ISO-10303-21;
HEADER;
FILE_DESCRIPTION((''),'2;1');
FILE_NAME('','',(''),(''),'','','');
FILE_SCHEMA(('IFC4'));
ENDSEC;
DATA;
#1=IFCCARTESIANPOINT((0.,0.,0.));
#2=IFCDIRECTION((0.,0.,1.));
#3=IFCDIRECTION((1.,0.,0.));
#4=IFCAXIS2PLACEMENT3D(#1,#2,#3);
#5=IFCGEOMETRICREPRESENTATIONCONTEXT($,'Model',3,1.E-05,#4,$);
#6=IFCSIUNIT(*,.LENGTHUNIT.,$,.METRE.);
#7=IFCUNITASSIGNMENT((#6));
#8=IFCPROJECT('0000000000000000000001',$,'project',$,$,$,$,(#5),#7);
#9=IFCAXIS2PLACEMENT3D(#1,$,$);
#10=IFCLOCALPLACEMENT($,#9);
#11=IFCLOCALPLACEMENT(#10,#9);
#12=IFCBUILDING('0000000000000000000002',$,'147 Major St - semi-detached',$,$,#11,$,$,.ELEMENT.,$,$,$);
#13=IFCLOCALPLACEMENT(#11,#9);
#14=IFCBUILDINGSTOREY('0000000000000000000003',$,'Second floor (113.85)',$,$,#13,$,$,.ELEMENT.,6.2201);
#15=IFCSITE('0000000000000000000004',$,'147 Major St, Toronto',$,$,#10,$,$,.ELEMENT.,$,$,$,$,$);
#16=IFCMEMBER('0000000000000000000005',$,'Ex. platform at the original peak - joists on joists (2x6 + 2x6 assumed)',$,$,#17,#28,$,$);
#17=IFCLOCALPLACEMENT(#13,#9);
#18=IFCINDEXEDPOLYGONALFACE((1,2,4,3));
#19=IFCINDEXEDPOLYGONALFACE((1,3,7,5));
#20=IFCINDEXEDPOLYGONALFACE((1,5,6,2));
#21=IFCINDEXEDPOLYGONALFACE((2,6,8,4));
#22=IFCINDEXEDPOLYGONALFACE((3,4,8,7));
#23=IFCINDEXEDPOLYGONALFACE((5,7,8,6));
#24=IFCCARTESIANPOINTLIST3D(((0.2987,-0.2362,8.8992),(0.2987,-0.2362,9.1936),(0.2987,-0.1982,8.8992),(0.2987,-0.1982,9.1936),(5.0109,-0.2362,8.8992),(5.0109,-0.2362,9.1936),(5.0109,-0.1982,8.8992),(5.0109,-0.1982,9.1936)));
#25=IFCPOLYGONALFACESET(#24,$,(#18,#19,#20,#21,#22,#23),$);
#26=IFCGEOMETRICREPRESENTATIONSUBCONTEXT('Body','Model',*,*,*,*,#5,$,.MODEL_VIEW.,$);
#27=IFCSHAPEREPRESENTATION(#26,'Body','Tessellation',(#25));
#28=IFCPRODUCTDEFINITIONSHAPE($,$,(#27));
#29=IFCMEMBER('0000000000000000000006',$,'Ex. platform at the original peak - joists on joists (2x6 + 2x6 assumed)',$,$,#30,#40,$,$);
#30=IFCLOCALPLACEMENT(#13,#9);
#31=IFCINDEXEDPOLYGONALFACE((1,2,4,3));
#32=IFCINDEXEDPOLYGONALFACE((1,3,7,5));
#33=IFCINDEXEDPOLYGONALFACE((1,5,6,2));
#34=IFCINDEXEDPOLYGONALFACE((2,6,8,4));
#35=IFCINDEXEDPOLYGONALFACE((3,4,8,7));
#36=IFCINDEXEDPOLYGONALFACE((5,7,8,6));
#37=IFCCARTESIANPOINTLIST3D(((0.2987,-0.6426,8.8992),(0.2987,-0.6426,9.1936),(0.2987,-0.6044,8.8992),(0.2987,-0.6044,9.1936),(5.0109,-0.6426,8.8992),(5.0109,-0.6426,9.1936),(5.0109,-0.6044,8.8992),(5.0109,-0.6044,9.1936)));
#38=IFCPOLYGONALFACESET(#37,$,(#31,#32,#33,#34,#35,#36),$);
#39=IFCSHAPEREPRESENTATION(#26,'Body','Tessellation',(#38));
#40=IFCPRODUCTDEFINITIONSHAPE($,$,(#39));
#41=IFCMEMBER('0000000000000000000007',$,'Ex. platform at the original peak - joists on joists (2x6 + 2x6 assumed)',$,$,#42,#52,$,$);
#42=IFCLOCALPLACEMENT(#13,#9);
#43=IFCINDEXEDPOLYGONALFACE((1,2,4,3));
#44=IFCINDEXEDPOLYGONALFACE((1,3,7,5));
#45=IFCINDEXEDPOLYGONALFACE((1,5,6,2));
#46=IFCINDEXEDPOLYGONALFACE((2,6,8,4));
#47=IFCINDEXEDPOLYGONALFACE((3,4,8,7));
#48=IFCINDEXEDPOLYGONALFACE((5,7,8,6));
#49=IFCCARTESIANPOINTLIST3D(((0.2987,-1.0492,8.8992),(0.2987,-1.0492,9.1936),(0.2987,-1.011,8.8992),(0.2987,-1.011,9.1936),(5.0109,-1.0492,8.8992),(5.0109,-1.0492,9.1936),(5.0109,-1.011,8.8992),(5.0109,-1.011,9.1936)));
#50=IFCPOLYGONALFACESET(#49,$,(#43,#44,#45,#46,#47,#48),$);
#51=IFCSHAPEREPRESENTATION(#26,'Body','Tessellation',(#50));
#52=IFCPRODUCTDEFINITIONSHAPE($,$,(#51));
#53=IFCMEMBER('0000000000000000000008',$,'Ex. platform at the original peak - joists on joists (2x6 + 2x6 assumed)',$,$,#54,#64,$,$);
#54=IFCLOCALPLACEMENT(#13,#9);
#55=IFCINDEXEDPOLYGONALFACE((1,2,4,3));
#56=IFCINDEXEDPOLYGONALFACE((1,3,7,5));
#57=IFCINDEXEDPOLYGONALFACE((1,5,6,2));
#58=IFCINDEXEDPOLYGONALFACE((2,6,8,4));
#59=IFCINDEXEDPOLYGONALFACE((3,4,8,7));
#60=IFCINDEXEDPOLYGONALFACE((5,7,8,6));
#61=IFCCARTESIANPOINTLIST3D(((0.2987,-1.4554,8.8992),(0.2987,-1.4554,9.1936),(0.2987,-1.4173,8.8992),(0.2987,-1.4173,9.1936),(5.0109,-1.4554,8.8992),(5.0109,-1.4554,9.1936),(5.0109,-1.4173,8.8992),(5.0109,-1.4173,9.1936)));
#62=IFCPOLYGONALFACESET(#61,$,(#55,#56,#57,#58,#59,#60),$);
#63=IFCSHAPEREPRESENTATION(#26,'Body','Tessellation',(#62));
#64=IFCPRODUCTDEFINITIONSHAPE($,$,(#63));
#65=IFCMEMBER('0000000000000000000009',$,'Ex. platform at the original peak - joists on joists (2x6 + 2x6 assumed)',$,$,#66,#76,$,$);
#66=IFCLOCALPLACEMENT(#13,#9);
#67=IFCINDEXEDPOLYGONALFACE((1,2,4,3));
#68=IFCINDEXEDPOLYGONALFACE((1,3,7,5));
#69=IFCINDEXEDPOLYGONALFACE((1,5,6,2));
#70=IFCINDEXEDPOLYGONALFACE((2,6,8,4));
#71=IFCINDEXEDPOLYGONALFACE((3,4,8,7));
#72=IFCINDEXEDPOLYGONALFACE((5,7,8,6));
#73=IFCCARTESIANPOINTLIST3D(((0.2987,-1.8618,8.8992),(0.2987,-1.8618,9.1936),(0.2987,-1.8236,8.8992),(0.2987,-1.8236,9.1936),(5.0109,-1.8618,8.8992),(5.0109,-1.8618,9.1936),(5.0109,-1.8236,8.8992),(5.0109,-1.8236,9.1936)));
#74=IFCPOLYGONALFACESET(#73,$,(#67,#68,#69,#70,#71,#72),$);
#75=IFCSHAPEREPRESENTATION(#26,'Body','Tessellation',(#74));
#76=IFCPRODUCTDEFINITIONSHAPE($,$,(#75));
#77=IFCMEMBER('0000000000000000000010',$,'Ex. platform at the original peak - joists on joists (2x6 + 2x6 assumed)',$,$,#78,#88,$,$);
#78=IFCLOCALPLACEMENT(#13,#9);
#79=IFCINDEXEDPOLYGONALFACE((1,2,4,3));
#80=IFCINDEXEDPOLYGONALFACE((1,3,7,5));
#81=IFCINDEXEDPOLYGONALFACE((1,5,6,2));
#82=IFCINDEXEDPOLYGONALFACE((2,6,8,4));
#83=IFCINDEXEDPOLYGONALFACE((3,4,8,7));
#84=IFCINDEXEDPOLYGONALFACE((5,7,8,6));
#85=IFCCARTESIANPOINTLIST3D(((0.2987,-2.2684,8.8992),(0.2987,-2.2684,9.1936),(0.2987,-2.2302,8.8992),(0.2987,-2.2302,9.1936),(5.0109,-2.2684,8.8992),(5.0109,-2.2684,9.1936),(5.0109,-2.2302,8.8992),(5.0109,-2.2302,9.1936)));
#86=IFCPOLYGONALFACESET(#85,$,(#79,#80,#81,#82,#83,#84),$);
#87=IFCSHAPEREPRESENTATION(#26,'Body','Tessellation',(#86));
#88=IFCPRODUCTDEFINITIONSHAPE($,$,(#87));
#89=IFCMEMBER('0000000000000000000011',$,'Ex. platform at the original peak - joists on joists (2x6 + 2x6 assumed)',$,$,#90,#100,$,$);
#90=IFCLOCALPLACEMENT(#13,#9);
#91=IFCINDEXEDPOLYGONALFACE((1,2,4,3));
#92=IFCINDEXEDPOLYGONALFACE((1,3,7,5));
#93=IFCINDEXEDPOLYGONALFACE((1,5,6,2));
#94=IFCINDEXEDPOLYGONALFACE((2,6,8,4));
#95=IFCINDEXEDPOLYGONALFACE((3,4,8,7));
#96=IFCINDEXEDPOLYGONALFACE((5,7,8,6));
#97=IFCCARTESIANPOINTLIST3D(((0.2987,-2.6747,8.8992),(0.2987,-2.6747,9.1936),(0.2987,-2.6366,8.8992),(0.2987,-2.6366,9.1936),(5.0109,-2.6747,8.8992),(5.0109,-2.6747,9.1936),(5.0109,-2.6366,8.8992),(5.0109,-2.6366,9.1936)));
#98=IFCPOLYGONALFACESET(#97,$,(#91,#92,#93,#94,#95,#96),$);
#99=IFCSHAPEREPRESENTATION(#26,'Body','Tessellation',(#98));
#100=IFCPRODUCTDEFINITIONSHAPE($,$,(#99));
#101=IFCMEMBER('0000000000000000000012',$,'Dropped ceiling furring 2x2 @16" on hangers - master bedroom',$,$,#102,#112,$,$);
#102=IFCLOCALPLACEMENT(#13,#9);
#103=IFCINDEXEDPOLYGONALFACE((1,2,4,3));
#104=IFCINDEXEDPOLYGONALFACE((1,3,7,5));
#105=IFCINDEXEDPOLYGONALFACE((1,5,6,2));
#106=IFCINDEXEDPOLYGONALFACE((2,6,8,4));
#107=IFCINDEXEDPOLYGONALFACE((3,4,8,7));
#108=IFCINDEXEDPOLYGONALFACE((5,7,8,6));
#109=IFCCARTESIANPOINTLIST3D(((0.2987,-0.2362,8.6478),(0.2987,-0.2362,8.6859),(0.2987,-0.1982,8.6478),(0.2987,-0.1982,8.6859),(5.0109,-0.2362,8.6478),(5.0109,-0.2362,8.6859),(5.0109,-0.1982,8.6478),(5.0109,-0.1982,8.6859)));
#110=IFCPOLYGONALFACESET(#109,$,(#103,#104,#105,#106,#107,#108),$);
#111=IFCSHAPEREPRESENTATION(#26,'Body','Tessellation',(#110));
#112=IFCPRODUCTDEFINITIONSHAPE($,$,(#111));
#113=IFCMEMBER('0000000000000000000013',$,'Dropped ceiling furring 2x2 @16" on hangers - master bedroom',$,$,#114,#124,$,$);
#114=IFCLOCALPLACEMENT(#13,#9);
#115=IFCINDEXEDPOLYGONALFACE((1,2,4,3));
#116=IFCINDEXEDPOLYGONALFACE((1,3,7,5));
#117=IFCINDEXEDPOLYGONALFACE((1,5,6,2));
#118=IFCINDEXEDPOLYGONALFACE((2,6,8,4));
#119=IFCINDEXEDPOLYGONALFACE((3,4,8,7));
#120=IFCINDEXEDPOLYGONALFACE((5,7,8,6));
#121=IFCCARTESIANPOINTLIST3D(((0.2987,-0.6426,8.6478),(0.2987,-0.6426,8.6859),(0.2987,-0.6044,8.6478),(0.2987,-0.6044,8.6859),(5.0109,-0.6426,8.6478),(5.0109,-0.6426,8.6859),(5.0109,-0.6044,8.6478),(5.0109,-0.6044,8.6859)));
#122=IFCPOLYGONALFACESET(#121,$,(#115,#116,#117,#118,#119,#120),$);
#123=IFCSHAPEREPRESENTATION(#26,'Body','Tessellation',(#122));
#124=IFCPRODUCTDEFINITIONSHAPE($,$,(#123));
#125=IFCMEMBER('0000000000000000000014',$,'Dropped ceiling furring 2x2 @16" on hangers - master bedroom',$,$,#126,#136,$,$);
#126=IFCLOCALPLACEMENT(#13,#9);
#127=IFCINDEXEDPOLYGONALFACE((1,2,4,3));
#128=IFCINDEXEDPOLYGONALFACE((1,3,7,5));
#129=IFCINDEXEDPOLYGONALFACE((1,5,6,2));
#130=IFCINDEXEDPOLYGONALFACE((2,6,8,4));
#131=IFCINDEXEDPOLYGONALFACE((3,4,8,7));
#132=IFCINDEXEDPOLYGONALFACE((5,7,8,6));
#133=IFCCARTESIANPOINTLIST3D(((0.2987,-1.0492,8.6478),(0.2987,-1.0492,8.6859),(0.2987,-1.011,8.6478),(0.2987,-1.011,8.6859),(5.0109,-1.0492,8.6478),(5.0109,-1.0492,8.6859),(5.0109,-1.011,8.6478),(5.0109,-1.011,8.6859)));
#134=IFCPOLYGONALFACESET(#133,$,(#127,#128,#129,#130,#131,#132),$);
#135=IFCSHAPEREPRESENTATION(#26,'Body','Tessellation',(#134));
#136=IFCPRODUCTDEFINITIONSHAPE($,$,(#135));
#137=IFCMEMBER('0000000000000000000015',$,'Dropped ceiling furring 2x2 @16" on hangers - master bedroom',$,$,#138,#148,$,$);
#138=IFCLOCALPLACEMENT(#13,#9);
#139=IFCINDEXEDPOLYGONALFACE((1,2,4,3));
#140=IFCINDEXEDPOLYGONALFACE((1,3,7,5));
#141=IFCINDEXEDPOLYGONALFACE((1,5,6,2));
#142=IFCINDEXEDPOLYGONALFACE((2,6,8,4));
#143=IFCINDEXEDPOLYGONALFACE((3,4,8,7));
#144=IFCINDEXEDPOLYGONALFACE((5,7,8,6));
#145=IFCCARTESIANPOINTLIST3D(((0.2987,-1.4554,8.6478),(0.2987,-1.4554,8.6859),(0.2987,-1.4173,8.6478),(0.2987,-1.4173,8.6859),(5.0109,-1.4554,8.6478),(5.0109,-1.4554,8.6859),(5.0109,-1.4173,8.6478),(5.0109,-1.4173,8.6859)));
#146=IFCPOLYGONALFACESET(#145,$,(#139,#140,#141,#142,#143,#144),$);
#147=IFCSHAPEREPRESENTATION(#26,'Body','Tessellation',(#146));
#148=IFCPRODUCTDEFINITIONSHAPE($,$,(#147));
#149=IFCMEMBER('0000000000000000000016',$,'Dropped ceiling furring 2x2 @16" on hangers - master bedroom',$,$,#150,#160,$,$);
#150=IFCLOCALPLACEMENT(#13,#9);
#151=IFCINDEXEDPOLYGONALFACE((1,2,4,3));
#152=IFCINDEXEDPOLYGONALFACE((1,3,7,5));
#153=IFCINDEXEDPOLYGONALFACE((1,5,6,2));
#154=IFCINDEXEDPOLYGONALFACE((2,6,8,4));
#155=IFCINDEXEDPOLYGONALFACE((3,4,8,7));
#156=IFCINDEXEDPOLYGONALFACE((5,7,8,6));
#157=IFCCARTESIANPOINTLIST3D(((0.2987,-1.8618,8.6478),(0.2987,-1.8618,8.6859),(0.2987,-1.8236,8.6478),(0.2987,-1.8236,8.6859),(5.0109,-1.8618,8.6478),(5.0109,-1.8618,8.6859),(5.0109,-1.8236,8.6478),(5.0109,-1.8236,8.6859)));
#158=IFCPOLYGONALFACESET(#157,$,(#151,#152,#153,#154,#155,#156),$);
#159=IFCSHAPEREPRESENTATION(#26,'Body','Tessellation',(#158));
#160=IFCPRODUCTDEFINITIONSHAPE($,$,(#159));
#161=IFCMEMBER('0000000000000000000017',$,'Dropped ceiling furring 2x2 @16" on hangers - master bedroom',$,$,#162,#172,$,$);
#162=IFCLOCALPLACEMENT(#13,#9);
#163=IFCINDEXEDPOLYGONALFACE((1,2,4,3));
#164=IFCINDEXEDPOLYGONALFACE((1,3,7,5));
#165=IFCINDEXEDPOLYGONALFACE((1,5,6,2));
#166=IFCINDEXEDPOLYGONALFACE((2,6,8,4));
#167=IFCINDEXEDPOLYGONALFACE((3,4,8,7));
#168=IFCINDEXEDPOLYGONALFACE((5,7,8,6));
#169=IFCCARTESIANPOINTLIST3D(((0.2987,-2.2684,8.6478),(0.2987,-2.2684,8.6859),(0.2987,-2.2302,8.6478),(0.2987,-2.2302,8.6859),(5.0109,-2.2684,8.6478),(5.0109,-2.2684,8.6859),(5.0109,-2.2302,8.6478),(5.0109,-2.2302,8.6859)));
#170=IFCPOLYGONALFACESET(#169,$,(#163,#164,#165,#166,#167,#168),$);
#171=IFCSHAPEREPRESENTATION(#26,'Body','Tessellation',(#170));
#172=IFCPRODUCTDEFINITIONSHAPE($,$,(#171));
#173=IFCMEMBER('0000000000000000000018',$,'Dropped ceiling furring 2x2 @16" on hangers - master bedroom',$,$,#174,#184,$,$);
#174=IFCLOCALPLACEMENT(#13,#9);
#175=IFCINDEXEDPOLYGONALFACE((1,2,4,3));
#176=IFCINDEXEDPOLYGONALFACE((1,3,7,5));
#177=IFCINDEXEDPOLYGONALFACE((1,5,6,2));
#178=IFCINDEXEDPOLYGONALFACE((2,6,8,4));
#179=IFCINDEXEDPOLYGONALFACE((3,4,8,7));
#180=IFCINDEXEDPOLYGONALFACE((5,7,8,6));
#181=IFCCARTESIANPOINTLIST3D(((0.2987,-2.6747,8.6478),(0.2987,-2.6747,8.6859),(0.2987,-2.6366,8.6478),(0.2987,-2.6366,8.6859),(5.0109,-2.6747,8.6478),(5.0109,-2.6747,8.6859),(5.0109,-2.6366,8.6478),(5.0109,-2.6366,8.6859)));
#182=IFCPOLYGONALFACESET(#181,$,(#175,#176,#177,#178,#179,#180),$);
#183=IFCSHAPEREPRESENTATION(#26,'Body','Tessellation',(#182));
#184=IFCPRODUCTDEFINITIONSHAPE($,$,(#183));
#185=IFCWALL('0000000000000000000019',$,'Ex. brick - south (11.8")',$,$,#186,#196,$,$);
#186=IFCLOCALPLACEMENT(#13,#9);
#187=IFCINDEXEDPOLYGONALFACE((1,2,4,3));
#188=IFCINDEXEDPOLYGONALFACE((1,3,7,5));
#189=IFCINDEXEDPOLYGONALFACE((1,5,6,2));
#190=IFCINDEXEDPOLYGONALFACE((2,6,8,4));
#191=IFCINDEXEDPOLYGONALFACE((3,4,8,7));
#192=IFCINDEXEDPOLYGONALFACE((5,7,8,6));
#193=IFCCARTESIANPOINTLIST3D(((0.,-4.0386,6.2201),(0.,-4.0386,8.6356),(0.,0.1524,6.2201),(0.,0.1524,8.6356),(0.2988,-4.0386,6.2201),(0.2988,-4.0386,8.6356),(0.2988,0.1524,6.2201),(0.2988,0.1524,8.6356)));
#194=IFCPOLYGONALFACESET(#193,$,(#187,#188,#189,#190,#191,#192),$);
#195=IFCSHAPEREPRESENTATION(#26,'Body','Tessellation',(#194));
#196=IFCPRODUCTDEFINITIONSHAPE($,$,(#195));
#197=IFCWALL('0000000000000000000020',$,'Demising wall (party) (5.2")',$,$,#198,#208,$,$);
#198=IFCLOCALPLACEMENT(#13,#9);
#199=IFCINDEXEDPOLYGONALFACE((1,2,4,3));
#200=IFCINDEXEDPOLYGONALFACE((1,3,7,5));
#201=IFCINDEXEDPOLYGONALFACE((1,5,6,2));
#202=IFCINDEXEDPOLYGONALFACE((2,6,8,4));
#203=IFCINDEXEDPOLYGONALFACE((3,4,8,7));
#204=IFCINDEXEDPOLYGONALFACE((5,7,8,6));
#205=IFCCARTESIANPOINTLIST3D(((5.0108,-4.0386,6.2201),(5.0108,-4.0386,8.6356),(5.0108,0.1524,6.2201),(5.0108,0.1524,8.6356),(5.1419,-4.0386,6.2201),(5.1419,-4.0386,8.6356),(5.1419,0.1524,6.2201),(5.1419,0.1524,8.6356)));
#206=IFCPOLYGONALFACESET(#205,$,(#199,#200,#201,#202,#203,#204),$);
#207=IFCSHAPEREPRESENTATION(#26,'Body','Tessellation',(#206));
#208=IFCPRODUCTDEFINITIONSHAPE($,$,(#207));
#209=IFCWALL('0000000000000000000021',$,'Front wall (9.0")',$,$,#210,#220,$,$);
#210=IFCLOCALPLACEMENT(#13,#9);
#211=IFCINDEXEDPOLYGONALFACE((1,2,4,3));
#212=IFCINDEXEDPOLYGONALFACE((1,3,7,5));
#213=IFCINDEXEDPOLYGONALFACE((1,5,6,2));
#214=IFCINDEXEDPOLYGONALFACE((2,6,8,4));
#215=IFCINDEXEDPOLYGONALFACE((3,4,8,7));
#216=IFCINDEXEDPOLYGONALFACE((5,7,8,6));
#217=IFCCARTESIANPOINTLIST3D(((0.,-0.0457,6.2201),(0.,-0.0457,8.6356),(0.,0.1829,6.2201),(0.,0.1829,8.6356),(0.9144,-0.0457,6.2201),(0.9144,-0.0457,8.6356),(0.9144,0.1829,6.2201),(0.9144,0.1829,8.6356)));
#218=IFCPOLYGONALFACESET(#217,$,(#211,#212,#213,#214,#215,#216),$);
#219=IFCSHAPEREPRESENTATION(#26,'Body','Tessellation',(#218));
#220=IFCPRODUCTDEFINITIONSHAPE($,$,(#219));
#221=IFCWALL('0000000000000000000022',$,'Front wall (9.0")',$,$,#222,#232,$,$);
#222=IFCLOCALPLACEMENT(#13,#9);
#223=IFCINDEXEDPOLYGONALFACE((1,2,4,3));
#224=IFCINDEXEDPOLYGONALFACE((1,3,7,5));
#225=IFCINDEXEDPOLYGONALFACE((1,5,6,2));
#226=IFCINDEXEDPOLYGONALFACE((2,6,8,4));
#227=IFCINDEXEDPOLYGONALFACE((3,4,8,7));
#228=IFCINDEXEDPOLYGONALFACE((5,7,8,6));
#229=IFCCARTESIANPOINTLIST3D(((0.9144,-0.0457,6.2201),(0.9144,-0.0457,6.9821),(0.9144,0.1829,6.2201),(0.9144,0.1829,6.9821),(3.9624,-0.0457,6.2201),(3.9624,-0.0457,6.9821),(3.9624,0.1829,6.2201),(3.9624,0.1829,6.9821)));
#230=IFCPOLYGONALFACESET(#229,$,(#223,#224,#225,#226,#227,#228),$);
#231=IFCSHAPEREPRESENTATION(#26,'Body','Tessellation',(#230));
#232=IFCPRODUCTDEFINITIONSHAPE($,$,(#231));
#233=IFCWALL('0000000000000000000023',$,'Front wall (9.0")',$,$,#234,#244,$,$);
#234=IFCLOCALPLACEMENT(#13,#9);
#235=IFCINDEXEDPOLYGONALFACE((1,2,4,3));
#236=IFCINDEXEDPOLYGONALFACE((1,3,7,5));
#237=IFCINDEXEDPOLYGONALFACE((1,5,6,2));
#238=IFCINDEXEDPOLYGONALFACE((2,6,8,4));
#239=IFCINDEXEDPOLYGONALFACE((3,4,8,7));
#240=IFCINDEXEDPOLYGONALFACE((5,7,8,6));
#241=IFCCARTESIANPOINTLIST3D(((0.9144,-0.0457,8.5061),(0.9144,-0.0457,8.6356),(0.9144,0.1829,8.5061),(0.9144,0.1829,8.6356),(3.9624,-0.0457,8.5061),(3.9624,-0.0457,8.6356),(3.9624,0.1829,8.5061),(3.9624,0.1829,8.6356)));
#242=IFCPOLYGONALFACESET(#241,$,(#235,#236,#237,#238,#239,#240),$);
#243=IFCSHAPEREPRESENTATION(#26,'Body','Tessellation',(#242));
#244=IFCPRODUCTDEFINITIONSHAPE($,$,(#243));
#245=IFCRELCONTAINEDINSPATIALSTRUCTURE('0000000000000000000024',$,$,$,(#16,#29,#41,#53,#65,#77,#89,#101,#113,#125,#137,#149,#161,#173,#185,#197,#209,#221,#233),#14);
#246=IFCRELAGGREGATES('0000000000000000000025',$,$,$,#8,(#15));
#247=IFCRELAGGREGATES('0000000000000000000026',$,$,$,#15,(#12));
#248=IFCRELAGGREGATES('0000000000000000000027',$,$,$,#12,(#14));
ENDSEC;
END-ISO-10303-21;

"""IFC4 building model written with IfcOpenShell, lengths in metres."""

from ifc_helpers import new_model, si_unit, frame, origin, origin_with_axes, place, context, subcontext, project, spatial, rectangle, extrude, element, save


model = new_model("IFC4")

# Units and contexts
model_context = context("Model", 3, precision=1e-05, world=origin_with_axes())
body_context = subcontext(model_context, "Body", "Model", "MODEL_VIEW")
ifc_project = project(units=[si_unit("LENGTHUNIT", "METRE")], contexts=[model_context])

# Site, building, storey
site_placement = place(None, origin())
site = spatial("IfcSite", under=ifc_project, at=site_placement, Name="147 Major St, Toronto", CompositionType="ELEMENT")
building_placement = place(site_placement, origin())
building = spatial("IfcBuilding", under=site, at=building_placement, Name="147 Major St - semi-detached", CompositionType="ELEMENT")
storey_placement = place(building_placement, origin())
storey = spatial("IfcBuildingStorey", under=building, at=storey_placement, Name="Second floor (113.85)", CompositionType="ELEMENT", Elevation=6.2201)

# Members
for number, where, name in (
    (1, (2.6548, -0.2172, 8.8992), "Ex. platform at the original peak - joists on joists (2x6 + 2x6 assumed)"),
    (2, (2.6548, -0.6235, 8.8992), "Ex. platform at the original peak - joists on joists (2x6 + 2x6 assumed)"),
    (3, (2.6548, -1.0301, 8.8992), "Ex. platform at the original peak - joists on joists (2x6 + 2x6 assumed)"),
    (4, (2.6548, -1.4364, 8.8992), "Ex. platform at the original peak - joists on joists (2x6 + 2x6 assumed)"),
    (5, (2.6548, -1.8427, 8.8992), "Ex. platform at the original peak - joists on joists (2x6 + 2x6 assumed)"),
    (6, (2.6548, -2.2493, 8.8992), "Ex. platform at the original peak - joists on joists (2x6 + 2x6 assumed)"),
    (7, (2.6548, -2.6556, 8.8992), "Ex. platform at the original peak - joists on joists (2x6 + 2x6 assumed)"),
):
    element("IfcMember", number, at=place(storey_placement, frame(where)), inside=storey, Name=name, context=body_context, shape_type="SweptSolid", body=[
        extrude(rectangle(XDim=4.7122, YDim=0.0381), origin_with_axes(), (0.0, 0.0, 1.0), 0.2944),
    ])
for number, where, name in (
    (8, (2.6548, -0.2172, 8.6478), "Dropped ceiling furring 2x2 @16\" on hangers - master bedroom"),
    (9, (2.6548, -0.6235, 8.6478), "Dropped ceiling furring 2x2 @16\" on hangers - master bedroom"),
    (10, (2.6548, -1.0301, 8.6478), "Dropped ceiling furring 2x2 @16\" on hangers - master bedroom"),
    (11, (2.6548, -1.4364, 8.6478), "Dropped ceiling furring 2x2 @16\" on hangers - master bedroom"),
    (12, (2.6548, -1.8427, 8.6478), "Dropped ceiling furring 2x2 @16\" on hangers - master bedroom"),
    (13, (2.6548, -2.2493, 8.6478), "Dropped ceiling furring 2x2 @16\" on hangers - master bedroom"),
    (14, (2.6548, -2.6556, 8.6478), "Dropped ceiling furring 2x2 @16\" on hangers - master bedroom"),
):
    element("IfcMember", number, at=place(storey_placement, frame(where)), inside=storey, Name=name, context=body_context, shape_type="SweptSolid", body=[
        extrude(rectangle(XDim=4.7122, YDim=0.0381), origin_with_axes(), (0.0, 0.0, 1.0), 0.0381),
    ])

# Walls
wall_1_placement = place(storey_placement, frame((0.1494, -1.9431, 6.2201)))
element("IfcWall", 15, at=wall_1_placement, inside=storey, Name="Ex. brick - south (11.8\")", context=body_context, shape_type="SweptSolid", body=[
    extrude(rectangle(XDim=0.2987, YDim=4.191), origin_with_axes(), (0.0, 0.0, 1.0), 2.4155),
])
wall_2_placement = place(storey_placement, frame((5.0764, -1.9431, 6.2201)))
element("IfcWall", 16, at=wall_2_placement, inside=storey, Name="Demising wall (party) (5.2\")", context=body_context, shape_type="SweptSolid", body=[
    extrude(rectangle(XDim=0.1311, YDim=4.191), origin_with_axes(), (0.0, 0.0, 1.0), 2.4155),
])
wall_3_placement = place(storey_placement, frame((0.4572, 0.0686, 6.2201)))
element("IfcWall", 17, at=wall_3_placement, inside=storey, Name="Front wall (9.0\")", context=body_context, shape_type="SweptSolid", body=[
    extrude(rectangle(XDim=0.9144, YDim=0.2286), origin_with_axes(), (0.0, 0.0, 1.0), 2.4155),
])
wall_4_placement = place(storey_placement, frame((2.4384, 0.0686, 6.2201)))
element("IfcWall", 18, at=wall_4_placement, inside=storey, Name="Front wall (9.0\")", context=body_context, shape_type="SweptSolid", body=[
    extrude(rectangle(XDim=3.048, YDim=0.2286), origin_with_axes(), (0.0, 0.0, 1.0), 0.762),
])
wall_5_placement = place(storey_placement, frame((2.4384, 0.0686, 8.5061)))
element("IfcWall", 19, at=wall_5_placement, inside=storey, Name="Front wall (9.0\")", context=body_context, shape_type="SweptSolid", body=[
    extrude(rectangle(XDim=3.048, YDim=0.2286), origin_with_axes(), (0.0, 0.0, 1.0), 0.1295),
])

save(model, "model.ifc")
